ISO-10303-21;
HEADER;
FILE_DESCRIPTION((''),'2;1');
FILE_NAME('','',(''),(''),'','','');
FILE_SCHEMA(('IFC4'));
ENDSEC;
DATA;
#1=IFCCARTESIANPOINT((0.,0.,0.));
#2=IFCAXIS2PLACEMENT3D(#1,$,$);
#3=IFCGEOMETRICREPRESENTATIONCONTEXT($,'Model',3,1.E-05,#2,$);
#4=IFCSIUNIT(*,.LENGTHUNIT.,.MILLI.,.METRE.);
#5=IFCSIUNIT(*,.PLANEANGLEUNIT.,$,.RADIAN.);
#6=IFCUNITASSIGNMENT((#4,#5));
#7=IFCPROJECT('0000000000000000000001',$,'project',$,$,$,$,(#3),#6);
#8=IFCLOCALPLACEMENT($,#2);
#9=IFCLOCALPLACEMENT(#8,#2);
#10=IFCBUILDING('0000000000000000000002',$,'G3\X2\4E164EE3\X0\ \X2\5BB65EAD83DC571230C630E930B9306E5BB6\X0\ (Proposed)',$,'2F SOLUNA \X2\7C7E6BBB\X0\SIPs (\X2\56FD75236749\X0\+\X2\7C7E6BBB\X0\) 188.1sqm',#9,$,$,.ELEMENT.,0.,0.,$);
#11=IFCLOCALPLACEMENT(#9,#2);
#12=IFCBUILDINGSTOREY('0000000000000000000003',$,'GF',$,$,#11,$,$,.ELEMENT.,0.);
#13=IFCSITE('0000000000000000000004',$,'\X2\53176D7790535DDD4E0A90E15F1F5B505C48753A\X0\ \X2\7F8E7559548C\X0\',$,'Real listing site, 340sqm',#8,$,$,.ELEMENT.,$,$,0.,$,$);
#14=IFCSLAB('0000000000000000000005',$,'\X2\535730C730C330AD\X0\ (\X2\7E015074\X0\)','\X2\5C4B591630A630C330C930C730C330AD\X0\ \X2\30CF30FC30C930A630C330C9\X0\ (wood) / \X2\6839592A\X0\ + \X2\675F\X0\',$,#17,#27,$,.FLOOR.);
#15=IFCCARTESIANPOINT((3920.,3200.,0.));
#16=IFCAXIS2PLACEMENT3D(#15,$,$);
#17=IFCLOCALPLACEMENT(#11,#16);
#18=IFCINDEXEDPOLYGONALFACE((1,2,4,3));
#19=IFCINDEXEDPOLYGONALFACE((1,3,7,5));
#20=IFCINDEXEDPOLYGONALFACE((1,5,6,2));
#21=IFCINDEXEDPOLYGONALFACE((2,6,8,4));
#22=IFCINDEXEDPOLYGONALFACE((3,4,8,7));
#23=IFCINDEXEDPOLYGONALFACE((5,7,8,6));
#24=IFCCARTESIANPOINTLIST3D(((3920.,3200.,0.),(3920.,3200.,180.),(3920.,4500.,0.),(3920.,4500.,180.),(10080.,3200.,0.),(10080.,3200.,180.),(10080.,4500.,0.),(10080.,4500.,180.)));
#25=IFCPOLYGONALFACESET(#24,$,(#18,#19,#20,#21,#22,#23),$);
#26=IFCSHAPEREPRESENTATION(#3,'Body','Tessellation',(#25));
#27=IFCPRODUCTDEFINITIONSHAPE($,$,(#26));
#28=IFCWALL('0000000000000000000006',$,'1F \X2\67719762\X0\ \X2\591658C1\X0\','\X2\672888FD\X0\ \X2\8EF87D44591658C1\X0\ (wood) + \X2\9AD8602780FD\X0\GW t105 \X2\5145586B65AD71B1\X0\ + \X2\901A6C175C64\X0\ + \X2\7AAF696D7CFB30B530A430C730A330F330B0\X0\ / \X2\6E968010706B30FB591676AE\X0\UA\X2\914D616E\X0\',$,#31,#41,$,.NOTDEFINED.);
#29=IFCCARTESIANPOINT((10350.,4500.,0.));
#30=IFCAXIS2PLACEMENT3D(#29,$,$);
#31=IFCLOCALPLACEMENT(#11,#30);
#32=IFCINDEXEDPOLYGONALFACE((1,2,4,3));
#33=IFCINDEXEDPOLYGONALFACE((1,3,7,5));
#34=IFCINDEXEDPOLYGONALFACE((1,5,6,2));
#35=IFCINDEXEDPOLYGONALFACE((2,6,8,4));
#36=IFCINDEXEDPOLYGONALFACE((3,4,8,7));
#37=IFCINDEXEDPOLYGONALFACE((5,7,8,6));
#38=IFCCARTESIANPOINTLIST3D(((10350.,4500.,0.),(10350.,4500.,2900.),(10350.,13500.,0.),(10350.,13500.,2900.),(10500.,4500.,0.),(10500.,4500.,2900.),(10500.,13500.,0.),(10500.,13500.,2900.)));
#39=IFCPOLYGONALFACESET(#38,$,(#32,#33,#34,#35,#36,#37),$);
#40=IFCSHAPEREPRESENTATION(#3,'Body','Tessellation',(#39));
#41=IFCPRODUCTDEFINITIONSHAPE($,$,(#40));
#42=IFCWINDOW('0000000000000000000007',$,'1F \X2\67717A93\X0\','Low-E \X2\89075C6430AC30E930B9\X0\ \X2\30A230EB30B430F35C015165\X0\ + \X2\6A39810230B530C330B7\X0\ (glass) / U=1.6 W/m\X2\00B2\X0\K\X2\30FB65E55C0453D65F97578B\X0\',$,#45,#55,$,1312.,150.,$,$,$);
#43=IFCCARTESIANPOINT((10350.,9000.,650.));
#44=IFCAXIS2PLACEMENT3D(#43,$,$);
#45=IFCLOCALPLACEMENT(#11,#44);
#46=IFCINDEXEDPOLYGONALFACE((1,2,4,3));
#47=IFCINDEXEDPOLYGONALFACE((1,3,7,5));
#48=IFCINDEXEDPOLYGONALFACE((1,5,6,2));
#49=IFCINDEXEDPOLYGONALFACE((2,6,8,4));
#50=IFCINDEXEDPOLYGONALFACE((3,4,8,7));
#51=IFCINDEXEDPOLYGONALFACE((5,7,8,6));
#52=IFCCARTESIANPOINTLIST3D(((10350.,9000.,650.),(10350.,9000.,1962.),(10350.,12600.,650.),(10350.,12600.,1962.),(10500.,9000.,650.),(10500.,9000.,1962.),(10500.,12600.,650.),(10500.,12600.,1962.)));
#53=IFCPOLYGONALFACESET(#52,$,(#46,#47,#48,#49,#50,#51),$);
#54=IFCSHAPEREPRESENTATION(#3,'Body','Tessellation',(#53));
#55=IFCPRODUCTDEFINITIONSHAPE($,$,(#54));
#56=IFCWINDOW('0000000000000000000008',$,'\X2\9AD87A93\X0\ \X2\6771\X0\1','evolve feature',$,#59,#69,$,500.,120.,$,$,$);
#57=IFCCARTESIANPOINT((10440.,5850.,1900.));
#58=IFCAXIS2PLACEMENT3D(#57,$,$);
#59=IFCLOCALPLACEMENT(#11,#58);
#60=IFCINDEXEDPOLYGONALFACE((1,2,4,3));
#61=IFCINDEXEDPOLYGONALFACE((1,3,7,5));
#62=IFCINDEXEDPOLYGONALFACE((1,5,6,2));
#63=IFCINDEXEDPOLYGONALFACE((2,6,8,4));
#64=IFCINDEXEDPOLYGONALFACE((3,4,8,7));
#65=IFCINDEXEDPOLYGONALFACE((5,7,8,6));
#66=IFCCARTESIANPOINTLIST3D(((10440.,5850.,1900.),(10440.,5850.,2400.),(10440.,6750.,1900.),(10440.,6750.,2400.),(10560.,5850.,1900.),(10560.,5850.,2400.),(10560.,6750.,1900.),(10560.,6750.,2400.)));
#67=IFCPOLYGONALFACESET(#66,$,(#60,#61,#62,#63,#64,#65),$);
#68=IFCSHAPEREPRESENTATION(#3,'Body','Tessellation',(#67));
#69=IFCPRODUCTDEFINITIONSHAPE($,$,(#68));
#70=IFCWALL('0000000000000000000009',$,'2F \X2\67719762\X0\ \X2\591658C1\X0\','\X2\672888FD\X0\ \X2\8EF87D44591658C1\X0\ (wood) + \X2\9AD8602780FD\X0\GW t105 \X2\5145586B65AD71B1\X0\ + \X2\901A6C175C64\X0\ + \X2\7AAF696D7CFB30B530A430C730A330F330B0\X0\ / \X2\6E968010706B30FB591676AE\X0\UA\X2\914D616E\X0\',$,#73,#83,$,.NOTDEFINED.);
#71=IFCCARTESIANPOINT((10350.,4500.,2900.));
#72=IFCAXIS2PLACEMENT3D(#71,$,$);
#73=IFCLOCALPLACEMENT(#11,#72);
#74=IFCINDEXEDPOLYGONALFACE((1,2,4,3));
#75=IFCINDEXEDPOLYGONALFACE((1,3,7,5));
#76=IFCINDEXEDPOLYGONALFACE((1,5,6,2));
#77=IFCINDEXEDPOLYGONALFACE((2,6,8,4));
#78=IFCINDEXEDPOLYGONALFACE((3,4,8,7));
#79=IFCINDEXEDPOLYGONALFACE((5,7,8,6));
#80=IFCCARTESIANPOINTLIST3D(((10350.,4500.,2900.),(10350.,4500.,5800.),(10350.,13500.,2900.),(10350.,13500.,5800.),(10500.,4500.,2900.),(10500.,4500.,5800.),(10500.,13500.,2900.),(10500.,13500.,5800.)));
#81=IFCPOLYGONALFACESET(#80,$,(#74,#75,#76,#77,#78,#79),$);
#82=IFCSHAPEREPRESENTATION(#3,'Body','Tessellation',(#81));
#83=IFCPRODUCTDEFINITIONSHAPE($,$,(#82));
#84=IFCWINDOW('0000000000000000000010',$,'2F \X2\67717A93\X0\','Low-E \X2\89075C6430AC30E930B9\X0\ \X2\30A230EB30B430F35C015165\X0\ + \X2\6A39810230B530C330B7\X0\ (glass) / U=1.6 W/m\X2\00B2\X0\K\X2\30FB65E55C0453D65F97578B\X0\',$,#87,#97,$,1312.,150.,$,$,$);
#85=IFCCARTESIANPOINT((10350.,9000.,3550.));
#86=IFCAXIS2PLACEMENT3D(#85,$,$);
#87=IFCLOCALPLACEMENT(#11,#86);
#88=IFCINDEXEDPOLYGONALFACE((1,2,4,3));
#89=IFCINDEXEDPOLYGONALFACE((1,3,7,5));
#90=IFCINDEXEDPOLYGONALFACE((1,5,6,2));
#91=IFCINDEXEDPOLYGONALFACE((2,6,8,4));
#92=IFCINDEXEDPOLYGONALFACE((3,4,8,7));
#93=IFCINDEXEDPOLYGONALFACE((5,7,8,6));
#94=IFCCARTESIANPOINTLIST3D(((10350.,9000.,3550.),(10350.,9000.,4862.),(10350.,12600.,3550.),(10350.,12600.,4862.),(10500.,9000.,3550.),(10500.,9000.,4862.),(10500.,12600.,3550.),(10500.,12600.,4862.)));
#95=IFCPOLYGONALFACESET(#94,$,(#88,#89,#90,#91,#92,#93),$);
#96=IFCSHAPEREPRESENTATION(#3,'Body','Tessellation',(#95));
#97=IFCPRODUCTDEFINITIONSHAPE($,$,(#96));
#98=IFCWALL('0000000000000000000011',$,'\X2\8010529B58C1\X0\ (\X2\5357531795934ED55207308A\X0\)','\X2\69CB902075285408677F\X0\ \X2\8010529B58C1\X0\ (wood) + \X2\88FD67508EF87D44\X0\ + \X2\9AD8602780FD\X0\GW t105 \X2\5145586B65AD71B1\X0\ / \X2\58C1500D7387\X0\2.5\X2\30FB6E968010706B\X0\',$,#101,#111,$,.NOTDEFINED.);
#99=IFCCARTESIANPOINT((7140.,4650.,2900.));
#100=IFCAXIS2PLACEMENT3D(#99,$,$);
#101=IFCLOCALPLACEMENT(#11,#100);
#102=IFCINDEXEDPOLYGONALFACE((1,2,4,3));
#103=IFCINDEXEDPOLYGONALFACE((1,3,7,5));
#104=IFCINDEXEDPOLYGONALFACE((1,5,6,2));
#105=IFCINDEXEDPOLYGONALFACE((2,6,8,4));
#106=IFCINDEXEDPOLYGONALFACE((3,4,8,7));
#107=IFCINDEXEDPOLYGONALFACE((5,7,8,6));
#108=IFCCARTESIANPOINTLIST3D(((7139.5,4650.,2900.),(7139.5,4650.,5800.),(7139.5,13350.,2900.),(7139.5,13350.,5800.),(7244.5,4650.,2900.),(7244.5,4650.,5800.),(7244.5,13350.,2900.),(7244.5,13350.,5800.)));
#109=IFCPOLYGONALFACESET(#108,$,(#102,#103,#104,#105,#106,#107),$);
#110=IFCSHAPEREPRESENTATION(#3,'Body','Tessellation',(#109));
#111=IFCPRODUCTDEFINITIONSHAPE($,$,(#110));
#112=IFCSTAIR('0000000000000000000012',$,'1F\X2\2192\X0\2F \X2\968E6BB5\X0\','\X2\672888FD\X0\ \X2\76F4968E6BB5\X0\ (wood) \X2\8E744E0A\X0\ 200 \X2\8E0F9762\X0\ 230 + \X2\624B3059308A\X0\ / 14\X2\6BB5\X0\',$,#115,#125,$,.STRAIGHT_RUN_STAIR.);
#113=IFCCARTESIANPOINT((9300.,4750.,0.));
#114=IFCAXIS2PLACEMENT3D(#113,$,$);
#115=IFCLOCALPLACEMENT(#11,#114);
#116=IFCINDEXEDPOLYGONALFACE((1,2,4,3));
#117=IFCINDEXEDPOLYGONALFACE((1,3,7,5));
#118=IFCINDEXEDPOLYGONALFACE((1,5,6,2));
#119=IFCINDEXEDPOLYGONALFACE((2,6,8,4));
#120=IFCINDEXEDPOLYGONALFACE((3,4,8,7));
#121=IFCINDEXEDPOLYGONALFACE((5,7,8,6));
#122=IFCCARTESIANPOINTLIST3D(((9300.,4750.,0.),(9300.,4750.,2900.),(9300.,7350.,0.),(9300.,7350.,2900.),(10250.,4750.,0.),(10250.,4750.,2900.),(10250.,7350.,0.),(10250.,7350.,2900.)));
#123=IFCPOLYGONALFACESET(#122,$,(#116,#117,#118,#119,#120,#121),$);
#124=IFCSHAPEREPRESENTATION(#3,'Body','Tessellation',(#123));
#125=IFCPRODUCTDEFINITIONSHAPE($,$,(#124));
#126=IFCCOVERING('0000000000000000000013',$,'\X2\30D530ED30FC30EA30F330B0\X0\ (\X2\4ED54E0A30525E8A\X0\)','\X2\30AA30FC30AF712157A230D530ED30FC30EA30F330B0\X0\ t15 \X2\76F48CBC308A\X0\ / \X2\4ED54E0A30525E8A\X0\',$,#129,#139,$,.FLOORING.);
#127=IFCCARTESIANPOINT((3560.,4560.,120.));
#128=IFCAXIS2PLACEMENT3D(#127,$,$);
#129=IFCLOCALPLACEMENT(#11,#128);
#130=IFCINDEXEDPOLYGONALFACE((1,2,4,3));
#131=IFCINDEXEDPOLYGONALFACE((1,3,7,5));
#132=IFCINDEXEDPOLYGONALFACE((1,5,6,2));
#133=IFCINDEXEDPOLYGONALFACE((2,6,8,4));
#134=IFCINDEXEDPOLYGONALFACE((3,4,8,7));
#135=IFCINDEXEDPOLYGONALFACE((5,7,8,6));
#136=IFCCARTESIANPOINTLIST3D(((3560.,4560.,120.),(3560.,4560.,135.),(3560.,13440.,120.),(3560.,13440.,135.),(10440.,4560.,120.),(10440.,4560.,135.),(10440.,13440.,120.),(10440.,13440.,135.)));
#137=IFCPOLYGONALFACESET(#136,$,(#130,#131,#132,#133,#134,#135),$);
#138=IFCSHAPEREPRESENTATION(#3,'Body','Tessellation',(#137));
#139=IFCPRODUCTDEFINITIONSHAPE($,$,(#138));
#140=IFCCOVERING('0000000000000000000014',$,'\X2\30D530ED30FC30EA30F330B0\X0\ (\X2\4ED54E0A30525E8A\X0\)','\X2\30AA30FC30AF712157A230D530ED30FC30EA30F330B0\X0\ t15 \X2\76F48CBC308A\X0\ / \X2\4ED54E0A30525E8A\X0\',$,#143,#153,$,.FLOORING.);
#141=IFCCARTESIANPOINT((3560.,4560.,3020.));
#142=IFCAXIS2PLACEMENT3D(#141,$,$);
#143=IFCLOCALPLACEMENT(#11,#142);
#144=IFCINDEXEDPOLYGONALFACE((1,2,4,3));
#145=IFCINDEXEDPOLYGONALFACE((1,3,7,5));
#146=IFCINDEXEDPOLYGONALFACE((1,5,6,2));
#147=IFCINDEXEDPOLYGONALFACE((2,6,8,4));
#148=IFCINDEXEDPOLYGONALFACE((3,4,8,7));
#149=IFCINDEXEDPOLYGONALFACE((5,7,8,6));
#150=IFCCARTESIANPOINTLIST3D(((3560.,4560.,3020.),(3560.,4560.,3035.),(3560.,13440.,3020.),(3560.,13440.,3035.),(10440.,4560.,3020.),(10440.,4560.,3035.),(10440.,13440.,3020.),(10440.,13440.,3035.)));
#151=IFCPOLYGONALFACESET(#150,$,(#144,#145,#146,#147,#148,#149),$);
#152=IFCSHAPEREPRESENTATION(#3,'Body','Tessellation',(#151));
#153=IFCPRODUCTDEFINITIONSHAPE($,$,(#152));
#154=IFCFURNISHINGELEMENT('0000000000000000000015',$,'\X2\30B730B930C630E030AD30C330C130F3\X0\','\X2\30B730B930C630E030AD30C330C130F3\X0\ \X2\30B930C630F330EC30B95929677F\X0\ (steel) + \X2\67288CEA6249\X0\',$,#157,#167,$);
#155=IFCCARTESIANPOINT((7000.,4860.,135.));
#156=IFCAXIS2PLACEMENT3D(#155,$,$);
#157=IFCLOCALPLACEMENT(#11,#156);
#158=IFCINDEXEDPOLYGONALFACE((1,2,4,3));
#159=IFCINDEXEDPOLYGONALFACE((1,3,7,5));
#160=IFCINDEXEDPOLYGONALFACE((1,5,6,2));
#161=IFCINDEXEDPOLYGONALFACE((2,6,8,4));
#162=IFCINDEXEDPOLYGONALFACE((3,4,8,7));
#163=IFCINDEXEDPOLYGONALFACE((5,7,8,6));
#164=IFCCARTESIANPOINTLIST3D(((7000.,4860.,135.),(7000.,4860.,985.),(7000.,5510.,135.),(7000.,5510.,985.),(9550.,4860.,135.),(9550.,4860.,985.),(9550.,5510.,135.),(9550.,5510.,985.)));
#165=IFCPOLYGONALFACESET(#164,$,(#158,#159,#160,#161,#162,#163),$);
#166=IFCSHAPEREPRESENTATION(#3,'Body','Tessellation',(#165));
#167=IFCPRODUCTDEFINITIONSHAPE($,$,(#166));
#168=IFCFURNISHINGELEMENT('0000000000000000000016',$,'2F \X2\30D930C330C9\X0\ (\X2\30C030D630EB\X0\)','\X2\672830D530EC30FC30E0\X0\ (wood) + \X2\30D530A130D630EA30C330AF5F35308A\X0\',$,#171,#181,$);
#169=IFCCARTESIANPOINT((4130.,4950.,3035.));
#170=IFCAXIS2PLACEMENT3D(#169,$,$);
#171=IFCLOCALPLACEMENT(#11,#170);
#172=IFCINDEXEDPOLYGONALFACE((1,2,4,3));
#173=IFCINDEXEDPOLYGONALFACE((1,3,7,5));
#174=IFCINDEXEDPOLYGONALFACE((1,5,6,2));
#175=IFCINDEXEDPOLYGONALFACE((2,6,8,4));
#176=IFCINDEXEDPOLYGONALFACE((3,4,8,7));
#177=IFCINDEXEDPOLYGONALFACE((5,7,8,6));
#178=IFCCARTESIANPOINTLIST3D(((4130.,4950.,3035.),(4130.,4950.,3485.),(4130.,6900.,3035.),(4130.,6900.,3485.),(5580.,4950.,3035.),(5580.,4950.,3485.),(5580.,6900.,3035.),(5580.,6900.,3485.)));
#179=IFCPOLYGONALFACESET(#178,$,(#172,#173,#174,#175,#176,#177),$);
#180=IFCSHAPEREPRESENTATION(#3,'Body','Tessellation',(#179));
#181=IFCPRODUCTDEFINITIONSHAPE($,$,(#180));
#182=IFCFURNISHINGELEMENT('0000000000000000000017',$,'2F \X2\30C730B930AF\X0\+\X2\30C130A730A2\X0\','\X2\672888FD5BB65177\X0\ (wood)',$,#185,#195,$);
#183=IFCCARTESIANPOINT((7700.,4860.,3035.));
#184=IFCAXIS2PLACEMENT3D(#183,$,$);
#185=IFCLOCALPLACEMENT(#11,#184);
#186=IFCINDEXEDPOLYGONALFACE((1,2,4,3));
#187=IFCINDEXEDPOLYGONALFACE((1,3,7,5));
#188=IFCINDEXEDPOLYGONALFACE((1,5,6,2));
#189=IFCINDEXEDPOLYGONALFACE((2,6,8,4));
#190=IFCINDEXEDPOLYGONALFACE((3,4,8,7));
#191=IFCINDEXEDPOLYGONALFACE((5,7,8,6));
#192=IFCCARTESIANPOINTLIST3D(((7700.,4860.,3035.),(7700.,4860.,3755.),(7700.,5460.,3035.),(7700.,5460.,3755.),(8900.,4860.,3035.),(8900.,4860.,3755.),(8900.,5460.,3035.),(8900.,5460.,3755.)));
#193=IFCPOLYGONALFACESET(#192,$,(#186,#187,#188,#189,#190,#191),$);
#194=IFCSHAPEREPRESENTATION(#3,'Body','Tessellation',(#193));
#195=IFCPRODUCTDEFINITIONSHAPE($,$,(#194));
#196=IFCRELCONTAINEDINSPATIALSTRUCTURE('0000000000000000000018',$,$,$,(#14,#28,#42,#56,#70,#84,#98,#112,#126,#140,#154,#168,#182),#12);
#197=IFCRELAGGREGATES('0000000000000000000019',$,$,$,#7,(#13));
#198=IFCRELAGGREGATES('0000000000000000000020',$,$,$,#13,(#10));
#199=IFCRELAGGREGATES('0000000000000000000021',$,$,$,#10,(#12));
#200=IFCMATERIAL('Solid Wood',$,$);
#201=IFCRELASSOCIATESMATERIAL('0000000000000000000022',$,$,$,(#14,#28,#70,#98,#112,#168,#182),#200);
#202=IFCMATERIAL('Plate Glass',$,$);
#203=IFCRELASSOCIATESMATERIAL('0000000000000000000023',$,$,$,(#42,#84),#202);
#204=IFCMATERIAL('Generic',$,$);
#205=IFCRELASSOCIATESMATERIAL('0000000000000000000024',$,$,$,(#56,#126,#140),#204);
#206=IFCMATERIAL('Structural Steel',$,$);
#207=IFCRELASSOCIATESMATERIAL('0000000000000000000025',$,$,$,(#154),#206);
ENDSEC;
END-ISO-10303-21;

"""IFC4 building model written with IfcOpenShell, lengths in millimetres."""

from ifc_helpers import new_model, si_unit, frame, frame_2d, origin, place, context, project, spatial, rectangle, extrude, material, element, fill, save


model = new_model("IFC4")

# Units and contexts
model_context = context("Model", 3, precision=1e-05, world=origin())
ifc_project = project(units=[si_unit("LENGTHUNIT", "METRE", prefix="MILLI"), si_unit("PLANEANGLEUNIT", "RADIAN")], contexts=[model_context])

# Site, building, storey
site_placement = place(None, origin())
site = spatial("IfcSite", under=ifc_project, at=site_placement, Name="北海道川上郡弟子屈町 美留和", ObjectType="Real listing site, 340sqm", CompositionType="ELEMENT", RefElevation=0.0)
building_placement = place(site_placement, origin())
building = spatial("IfcBuilding", under=site, at=building_placement, Name="G3世代 家庭菜園テラスの家 (Proposed)", ObjectType="2F SOLUNA 籾殻SIPs (国産杉+籾殻) 188.1sqm", CompositionType="ELEMENT", ElevationOfRefHeight=0.0, ElevationOfTerrain=0.0)
storey_placement = place(building_placement, origin())
storey = spatial("IfcBuildingStorey", under=building, at=storey_placement, Name="GF", CompositionType="ELEMENT", Elevation=0.0)

# Slab
ifc_material_1 = material(Name="Solid Wood")
slab_placement = place(storey_placement, frame((3920.0, 3200.0, 0.0)))
element("IfcSlab", 1, at=slab_placement, inside=storey, material=ifc_material_1, Name="南デッキ (縁側)", Description="屋外ウッドデッキ ハードウッド (wood) / 根太 + 束", PredefinedType="FLOOR", context=model_context, shape_type="SweptSolid", body=[
    extrude(rectangle(XDim=6160.0, YDim=1300.0, at=frame_2d((3080.0, 650.0))), frame((3920.0, 3200.0, 0.0)), (0.0, 0.0, 1.0), 180.0),
])

# Wall, openings, windows
wall_1_placement = place(storey_placement, frame((10350.0, 4500.0, 0.0)))
wall_1 = element("IfcWall", 2, at=wall_1_placement, inside=storey, material=ifc_material_1, Name="1F 東面 外壁", Description="木製 軸組外壁 (wood) + 高性能GW t105 充填断熱 + 通気層 + 窯業系サイディング / 準耐火・外皮UA配慮", PredefinedType="NOTDEFINED", context=model_context, shape_type="SweptSolid", body=[
    extrude(rectangle(XDim=150.0, YDim=9000.0, at=frame_2d((75.0, 4500.0))), frame((10350.0, 4500.0, 0.0)), (0.0, 0.0, 1.0), 2900.0),
])
opening_1_placement = place(storey_placement, frame((10350.0, 9000.0, 650.0)))
opening_1 = element("IfcOpeningElement", 3, at=opening_1_placement, cuts=wall_1, PredefinedType="NOTDEFINED", context=model_context, shape_type="SweptSolid", body=[
    extrude(rectangle(XDim=150.0, YDim=3600.0, at=frame_2d((75.0, 1800.0))), frame((10350.0, 9000.0, 650.0)), (0.0, 0.0, 1.0), 1312.0),
])
opening_2_placement = place(storey_placement, frame((10440.0, 5850.0, 1900.0)))
opening_2 = element("IfcOpeningElement", 4, at=opening_2_placement, cuts=wall_1, PredefinedType="NOTDEFINED", context=model_context, shape_type="SweptSolid", body=[
    extrude(rectangle(XDim=120.0, YDim=900.0, at=frame_2d((60.0, 450.0))), frame((10440.0, 5850.0, 1900.0)), (0.0, 0.0, 1.0), 500.0),
])
ifc_material_2 = material(Name="Plate Glass")
window_1_placement = place(storey_placement, frame((10350.0, 9000.0, 650.0)))
window_1 = element("IfcWindow", 5, at=window_1_placement, inside=storey, material=ifc_material_2, Name="1F 東窓", Description="Low-E 複層ガラス アルゴン封入 + 樹脂サッシ (glass) / U=1.6 W/m²K・日射取得型", OverallHeight=1312.0, OverallWidth=150.0, context=model_context, shape_type="SweptSolid", body=[
    extrude(rectangle(XDim=150.0, YDim=3600.0, at=frame_2d((75.0, 1800.0))), frame((10350.0, 9000.0, 650.0)), (0.0, 0.0, 1.0), 1312.0),
])
fill(opening_1, window_1)
ifc_material_3 = material(Name="Generic")
window_2_placement = place(storey_placement, frame((10440.0, 5850.0, 1900.0)))
window_2 = element("IfcWindow", 6, at=window_2_placement, inside=storey, material=ifc_material_3, Name="高窓 東1", Description="evolve feature", OverallHeight=500.0, OverallWidth=120.0, context=model_context, shape_type="SweptSolid", body=[
    extrude(rectangle(XDim=120.0, YDim=900.0, at=frame_2d((60.0, 450.0))), frame((10440.0, 5850.0, 1900.0)), (0.0, 0.0, 1.0), 500.0),
])
fill(opening_2, window_2)

# Wall, opening, window
wall_2_placement = place(storey_placement, frame((10350.0, 4500.0, 2900.0)))
wall_2 = element("IfcWall", 7, at=wall_2_placement, inside=storey, material=ifc_material_1, Name="2F 東面 外壁", Description="木製 軸組外壁 (wood) + 高性能GW t105 充填断熱 + 通気層 + 窯業系サイディング / 準耐火・外皮UA配慮", PredefinedType="NOTDEFINED", context=model_context, shape_type="SweptSolid", body=[
    extrude(rectangle(XDim=150.0, YDim=9000.0, at=frame_2d((75.0, 4500.0))), frame((10350.0, 4500.0, 2900.0)), (0.0, 0.0, 1.0), 2900.0),
])
opening_3_placement = place(storey_placement, frame((10350.0, 9000.0, 3550.0)))
opening_3 = element("IfcOpeningElement", 8, at=opening_3_placement, cuts=wall_2, PredefinedType="NOTDEFINED", context=model_context, shape_type="SweptSolid", body=[
    extrude(rectangle(XDim=150.0, YDim=3600.0, at=frame_2d((75.0, 1800.0))), frame((10350.0, 9000.0, 3550.0)), (0.0, 0.0, 1.0), 1312.0),
])
window_3_placement = place(storey_placement, frame((10350.0, 9000.0, 3550.0)))
window_3 = element("IfcWindow", 9, at=window_3_placement, inside=storey, material=ifc_material_2, Name="2F 東窓", Description="Low-E 複層ガラス アルゴン封入 + 樹脂サッシ (glass) / U=1.6 W/m²K・日射取得型", OverallHeight=1312.0, OverallWidth=150.0, context=model_context, shape_type="SweptSolid", body=[
    extrude(rectangle(XDim=150.0, YDim=3600.0, at=frame_2d((75.0, 1800.0))), frame((10350.0, 9000.0, 3550.0)), (0.0, 0.0, 1.0), 1312.0),
])
fill(opening_3, window_3)

# Wall
wall_3_placement = place(storey_placement, frame((7140.0, 4650.0, 2900.0)))
element("IfcWall", 10, at=wall_3_placement, inside=storey, material=ifc_material_1, Name="耐力壁 (南北間仕切り)", Description="構造用合板 耐力壁 (wood) + 製材軸組 + 高性能GW t105 充填断熱 / 壁倍率2.5・準耐火", PredefinedType="NOTDEFINED", context=model_context, shape_type="SweptSolid", body=[
    extrude(rectangle(XDim=105.0, YDim=8700.0, at=frame_2d((52.0, 4350.0))), frame((7140.0, 4650.0, 2900.0)), (0.0, 0.0, 1.0), 2900.0),
])

# Stair
stair_placement = place(storey_placement, frame((9300.0, 4750.0, 0.0)))
element("IfcStair", 11, at=stair_placement, inside=storey, material=ifc_material_1, Name="1F→2F 階段", Description="木製 直階段 (wood) 蹴上 200 踏面 230 + 手すり / 14段", PredefinedType="STRAIGHT_RUN_STAIR", context=model_context, shape_type="SweptSolid", body=[
    extrude(rectangle(XDim=950.0, YDim=2600.0, at=frame_2d((475.0, 1300.0))), frame((9300.0, 4750.0, 0.0)), (0.0, 0.0, 1.0), 2900.0),
])

# Coverings
covering_1_placement = place(storey_placement, frame((3560.0, 4560.0, 120.0)))
element("IfcCovering", 12, at=covering_1_placement, inside=storey, material=ifc_material_3, Name="フローリング (仕上げ床)", Description="オーク無垢フローリング t15 直貼り / 仕上げ床", PredefinedType="FLOORING", context=model_context, shape_type="SweptSolid", body=[
    extrude(rectangle(XDim=6880.0, YDim=8880.0, at=frame_2d((3440.0, 4440.0))), frame((3560.0, 4560.0, 120.0)), (0.0, 0.0, 1.0), 15.0),
])
covering_2_placement = place(storey_placement, frame((3560.0, 4560.0, 3020.0)))
element("IfcCovering", 13, at=covering_2_placement, inside=storey, material=ifc_material_3, Name="フローリング (仕上げ床)", Description="オーク無垢フローリング t15 直貼り / 仕上げ床", PredefinedType="FLOORING", context=model_context, shape_type="SweptSolid", body=[
    extrude(rectangle(XDim=6880.0, YDim=8880.0, at=frame_2d((3440.0, 4440.0))), frame((3560.0, 4560.0, 3020.0)), (0.0, 0.0, 1.0), 15.0),
])

# Furnishing elements
ifc_material_4 = material(Name="Structural Steel")
furnishing_1_placement = place(storey_placement, frame((7000.0, 4860.0, 135.0)))
element("IfcFurnishingElement", 14, at=furnishing_1_placement, inside=storey, material=ifc_material_4, Name="システムキッチン", Description="システムキッチン ステンレス天板 (steel) + 木質扉", context=model_context, shape_type="SweptSolid", body=[
    extrude(rectangle(XDim=2550.0, YDim=650.0, at=frame_2d((1275.0, 325.0))), frame((7000.0, 4860.0, 135.0)), (0.0, 0.0, 1.0), 850.0),
])
furnishing_2_placement = place(storey_placement, frame((4130.0, 4950.0, 3035.0)))
element("IfcFurnishingElement", 15, at=furnishing_2_placement, inside=storey, material=ifc_material_1, Name="2F ベッド (ダブル)", Description="木フレーム (wood) + ファブリック張り", context=model_context, shape_type="SweptSolid", body=[
    extrude(rectangle(XDim=1450.0, YDim=1950.0, at=frame_2d((725.0, 975.0))), frame((4130.0, 4950.0, 3035.0)), (0.0, 0.0, 1.0), 450.0),
])
furnishing_3_placement = place(storey_placement, frame((7700.0, 4860.0, 3035.0)))
element("IfcFurnishingElement", 16, at=furnishing_3_placement, inside=storey, material=ifc_material_1, Name="2F デスク+チェア", Description="木製家具 (wood)", context=model_context, shape_type="SweptSolid", body=[
    extrude(rectangle(XDim=1200.0, YDim=600.0, at=frame_2d((600.0, 300.0))), frame((7700.0, 4860.0, 3035.0)), (0.0, 0.0, 1.0), 720.0),
])

save(model, "model.ifc")
